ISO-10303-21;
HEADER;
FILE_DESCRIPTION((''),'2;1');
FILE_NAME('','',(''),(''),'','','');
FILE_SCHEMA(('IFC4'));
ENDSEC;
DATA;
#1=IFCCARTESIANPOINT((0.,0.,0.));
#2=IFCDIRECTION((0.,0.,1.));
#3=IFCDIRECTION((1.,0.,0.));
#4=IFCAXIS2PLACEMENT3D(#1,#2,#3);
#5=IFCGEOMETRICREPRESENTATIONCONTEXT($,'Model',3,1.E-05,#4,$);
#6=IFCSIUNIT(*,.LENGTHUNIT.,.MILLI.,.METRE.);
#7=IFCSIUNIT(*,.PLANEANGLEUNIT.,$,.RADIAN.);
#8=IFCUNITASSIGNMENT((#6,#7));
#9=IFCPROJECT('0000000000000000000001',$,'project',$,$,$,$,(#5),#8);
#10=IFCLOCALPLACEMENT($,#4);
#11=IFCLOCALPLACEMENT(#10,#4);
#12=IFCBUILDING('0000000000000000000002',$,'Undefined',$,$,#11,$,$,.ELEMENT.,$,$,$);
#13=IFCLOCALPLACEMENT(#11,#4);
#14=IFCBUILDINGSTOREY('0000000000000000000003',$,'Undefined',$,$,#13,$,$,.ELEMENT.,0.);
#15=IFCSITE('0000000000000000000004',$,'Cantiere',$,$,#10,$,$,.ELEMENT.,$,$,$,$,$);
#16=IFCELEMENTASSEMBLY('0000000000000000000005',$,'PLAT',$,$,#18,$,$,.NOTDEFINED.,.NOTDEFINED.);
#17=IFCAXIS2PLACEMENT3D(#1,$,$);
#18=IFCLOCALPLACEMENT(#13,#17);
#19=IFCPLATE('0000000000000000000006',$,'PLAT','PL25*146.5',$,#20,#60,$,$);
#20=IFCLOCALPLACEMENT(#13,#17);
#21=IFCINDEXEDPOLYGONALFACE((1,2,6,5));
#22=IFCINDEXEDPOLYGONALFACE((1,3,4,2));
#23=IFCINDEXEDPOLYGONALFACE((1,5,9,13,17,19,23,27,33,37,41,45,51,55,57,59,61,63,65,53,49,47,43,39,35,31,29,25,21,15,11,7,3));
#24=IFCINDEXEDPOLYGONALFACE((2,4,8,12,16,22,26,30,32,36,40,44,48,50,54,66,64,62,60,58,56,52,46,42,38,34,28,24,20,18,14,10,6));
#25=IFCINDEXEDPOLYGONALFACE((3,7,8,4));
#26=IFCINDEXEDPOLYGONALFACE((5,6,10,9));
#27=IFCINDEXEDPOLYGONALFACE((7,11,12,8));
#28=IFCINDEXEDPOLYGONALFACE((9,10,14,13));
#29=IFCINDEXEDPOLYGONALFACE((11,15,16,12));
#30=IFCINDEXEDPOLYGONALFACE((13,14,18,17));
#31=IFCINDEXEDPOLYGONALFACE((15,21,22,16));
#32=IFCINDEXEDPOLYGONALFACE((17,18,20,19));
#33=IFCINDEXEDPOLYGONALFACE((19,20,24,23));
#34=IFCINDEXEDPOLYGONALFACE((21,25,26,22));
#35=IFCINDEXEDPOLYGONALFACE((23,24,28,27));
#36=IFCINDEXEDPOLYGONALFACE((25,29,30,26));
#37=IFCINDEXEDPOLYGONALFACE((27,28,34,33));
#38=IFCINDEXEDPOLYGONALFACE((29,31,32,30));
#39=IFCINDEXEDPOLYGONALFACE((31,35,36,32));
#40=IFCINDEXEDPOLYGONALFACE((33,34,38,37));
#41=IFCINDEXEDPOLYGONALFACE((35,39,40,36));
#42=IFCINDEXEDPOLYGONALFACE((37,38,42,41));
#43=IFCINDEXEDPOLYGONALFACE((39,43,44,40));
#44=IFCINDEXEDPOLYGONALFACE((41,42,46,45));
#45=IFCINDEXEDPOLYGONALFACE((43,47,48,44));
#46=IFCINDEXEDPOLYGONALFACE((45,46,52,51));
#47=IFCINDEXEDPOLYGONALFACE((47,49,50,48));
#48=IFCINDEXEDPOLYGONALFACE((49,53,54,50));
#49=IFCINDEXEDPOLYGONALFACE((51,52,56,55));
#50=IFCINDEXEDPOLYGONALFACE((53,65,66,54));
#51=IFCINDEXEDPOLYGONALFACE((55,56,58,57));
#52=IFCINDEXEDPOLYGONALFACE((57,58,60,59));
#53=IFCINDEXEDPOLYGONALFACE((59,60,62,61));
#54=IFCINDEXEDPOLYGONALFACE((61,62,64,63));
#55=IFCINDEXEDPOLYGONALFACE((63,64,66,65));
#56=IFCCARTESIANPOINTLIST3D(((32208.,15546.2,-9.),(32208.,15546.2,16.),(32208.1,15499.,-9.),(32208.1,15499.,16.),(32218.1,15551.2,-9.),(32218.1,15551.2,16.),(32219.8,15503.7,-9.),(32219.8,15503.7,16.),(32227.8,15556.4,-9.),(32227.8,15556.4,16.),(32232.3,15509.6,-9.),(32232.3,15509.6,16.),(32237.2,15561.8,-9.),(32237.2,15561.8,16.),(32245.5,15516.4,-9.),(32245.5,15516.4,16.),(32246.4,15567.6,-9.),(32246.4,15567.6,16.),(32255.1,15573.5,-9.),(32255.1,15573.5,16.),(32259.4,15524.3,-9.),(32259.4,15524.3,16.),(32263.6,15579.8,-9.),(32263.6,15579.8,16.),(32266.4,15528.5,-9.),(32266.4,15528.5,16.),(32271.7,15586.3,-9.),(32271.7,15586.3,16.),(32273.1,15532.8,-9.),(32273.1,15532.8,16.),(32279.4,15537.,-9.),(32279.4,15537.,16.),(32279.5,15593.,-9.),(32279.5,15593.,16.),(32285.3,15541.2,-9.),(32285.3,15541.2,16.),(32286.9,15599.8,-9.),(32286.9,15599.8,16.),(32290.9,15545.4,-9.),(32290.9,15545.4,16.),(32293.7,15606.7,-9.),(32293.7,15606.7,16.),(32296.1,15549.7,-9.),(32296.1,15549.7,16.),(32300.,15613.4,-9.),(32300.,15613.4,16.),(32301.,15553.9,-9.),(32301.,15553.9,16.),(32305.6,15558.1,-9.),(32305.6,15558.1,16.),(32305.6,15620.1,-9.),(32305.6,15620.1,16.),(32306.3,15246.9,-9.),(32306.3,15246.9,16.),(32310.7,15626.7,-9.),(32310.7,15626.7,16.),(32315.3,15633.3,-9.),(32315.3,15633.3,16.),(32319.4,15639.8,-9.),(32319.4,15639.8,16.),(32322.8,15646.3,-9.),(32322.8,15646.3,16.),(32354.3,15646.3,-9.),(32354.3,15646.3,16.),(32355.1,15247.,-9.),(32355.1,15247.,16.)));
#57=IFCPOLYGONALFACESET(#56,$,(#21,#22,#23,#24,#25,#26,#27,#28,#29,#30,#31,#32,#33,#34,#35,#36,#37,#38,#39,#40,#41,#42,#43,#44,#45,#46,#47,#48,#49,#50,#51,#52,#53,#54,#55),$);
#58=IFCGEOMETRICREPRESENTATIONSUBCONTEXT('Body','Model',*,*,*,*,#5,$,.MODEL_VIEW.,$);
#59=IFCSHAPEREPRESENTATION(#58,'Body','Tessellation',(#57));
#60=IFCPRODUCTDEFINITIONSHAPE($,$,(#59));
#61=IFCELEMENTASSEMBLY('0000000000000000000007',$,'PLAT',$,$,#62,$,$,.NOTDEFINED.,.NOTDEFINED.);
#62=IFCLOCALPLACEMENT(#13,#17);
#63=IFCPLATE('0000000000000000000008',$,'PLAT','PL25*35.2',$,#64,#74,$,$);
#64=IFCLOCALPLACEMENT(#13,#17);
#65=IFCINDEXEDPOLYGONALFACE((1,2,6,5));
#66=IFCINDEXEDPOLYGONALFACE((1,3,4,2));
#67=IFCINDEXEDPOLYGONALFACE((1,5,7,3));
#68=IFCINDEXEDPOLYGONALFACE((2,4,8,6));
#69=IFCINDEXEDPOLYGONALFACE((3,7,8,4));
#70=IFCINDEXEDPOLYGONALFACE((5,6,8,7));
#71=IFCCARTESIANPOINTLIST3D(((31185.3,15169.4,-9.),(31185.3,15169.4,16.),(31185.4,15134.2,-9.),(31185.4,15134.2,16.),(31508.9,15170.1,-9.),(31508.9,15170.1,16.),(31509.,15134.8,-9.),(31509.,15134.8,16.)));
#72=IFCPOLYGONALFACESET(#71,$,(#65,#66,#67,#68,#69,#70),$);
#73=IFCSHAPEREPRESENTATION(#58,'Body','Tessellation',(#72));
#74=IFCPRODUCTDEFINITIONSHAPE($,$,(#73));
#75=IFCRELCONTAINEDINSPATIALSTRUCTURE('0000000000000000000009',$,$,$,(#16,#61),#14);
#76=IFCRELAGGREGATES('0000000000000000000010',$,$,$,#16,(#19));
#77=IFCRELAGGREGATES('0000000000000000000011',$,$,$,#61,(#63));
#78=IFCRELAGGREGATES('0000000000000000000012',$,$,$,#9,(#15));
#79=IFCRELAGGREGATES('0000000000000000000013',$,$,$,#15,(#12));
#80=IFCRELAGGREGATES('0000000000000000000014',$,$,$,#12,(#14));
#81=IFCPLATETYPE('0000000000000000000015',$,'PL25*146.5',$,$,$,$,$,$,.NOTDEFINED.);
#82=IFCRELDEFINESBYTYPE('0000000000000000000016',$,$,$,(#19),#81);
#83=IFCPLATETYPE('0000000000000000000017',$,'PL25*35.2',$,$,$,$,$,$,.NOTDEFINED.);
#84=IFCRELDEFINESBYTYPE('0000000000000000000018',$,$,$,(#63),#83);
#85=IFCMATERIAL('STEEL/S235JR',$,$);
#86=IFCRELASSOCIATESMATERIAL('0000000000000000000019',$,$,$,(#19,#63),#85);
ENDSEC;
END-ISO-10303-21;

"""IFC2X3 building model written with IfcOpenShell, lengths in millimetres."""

from ifc_helpers import new_model, si_unit, frame, origin_with_axes, place, context, subcontext, project, spatial, polyline, outline, extrude, material, type_object, element, aggregate, save


model = new_model("IFC2X3")

# Units and contexts
model_context = context("Model", 3, precision=1e-05, world=origin_with_axes())
body_context = subcontext(model_context, "Body", "Model", "MODEL_VIEW")
ifc_project = project(units=[si_unit("LENGTHUNIT", "METRE", prefix="MILLI"), si_unit("PLANEANGLEUNIT", "RADIAN")], contexts=[model_context])

# Site, building, storey
site_placement = place(None, origin_with_axes())
site = spatial("IfcSite", under=ifc_project, at=site_placement, Name="Cantiere", CompositionType="ELEMENT")
building_placement = place(site_placement, origin_with_axes())
building = spatial("IfcBuilding", under=site, at=building_placement, Name="Undefined", CompositionType="ELEMENT")
storey_placement = place(building_placement, origin_with_axes())
storey = spatial("IfcBuildingStorey", under=building, at=storey_placement, Name="Undefined", CompositionType="ELEMENT", Elevation=0.0)

# Element assemblies, plates
ifc_material_1 = material(Name="STEEL/S235JR")
assembly_1_placement = place(storey_placement, origin_with_axes())
assembly_1 = element("IfcElementAssembly", 1, at=assembly_1_placement, inside=storey, Name="PLAT", AssemblyPlace="NOTDEFINED", PredefinedType="NOTDEFINED")
plate_type_1 = type_object("IfcPlateType", Name="PL25*146.5", PredefinedType="NOTDEFINED")
plate_1_placement = place(assembly_1_placement, frame((32355.1, 15247.0, 3.5), z_axis=(0.0, 0.000001, -1.0), x_axis=(-0.999998, -0.00212, 0.0)))
plate_1 = element("IfcPlate", 2, at=plate_1_placement, type_object=plate_type_1, material=ifc_material_1, Name="PLAT", Description="PL25*146.5", context=body_context, shape_type="SweptSolid", body=[
    extrude(outline(polyline([(0.0, 0.0), (48.9, 0.0), (48.9, 311.2), (53.4, 307.0), (58.4, 302.7), (63.6, 298.6), (69.2, 294.3), (75.1, 290.1), (81.5, 285.9), (88.1, 281.7), (95.1, 277.5), (109.0, 269.6), (122.3, 262.8), (134.8, 257.0), (146.5, 252.3), (146.5, 299.5), (136.4, 304.5), (126.6, 309.6), (117.2, 315.1), (108.1, 320.7), (99.3, 326.7), (90.9, 333.0), (82.7, 339.4), (74.9, 346.2), (67.5, 353.0), (60.7, 359.8), (54.4, 366.5), (48.7, 373.2), (43.6, 379.8), (39.0, 386.4), (34.9, 392.9), (31.5, 399.3), (0.0, 399.3), (0.0, 0.0)])), frame((0.0, 0.0, -12.5), z_axis=(0.0, 0.0, 1.0), x_axis=(1.0, 0.0, 0.0)), (0.0, 0.0, 1.0), 25.0),
])
aggregate(assembly_1, [plate_1])
assembly_2_placement = place(storey_placement, origin_with_axes())
assembly_2 = element("IfcElementAssembly", 3, at=assembly_2_placement, inside=storey, Name="PLAT", AssemblyPlace="NOTDEFINED", PredefinedType="NOTDEFINED")
plate_type_2 = type_object("IfcPlateType", Name="PL25*35.2", PredefinedType="NOTDEFINED")
plate_2_placement = place(assembly_2_placement, frame((31185.4, 15134.2, 3.5), z_axis=(0.0, 0.000001, -1.0), x_axis=(-0.00212, 0.999998, 0.0)))
plate_2 = element("IfcPlate", 4, at=plate_2_placement, type_object=plate_type_2, material=ifc_material_1, Name="PLAT", Description="PL25*35.2", context=body_context, shape_type="SweptSolid", body=[
    extrude(outline(polyline([(0.0, 0.0), (35.2, 0.0), (35.2, 323.7), (0.0, 323.7), (0.0, 0.0)])), frame((0.0, 0.0, -12.5), z_axis=(0.0, 0.0, 1.0), x_axis=(1.0, 0.0, 0.0)), (0.0, 0.0, 1.0), 25.0),
])
aggregate(assembly_2, [plate_2])

save(model, "model.ifc")
